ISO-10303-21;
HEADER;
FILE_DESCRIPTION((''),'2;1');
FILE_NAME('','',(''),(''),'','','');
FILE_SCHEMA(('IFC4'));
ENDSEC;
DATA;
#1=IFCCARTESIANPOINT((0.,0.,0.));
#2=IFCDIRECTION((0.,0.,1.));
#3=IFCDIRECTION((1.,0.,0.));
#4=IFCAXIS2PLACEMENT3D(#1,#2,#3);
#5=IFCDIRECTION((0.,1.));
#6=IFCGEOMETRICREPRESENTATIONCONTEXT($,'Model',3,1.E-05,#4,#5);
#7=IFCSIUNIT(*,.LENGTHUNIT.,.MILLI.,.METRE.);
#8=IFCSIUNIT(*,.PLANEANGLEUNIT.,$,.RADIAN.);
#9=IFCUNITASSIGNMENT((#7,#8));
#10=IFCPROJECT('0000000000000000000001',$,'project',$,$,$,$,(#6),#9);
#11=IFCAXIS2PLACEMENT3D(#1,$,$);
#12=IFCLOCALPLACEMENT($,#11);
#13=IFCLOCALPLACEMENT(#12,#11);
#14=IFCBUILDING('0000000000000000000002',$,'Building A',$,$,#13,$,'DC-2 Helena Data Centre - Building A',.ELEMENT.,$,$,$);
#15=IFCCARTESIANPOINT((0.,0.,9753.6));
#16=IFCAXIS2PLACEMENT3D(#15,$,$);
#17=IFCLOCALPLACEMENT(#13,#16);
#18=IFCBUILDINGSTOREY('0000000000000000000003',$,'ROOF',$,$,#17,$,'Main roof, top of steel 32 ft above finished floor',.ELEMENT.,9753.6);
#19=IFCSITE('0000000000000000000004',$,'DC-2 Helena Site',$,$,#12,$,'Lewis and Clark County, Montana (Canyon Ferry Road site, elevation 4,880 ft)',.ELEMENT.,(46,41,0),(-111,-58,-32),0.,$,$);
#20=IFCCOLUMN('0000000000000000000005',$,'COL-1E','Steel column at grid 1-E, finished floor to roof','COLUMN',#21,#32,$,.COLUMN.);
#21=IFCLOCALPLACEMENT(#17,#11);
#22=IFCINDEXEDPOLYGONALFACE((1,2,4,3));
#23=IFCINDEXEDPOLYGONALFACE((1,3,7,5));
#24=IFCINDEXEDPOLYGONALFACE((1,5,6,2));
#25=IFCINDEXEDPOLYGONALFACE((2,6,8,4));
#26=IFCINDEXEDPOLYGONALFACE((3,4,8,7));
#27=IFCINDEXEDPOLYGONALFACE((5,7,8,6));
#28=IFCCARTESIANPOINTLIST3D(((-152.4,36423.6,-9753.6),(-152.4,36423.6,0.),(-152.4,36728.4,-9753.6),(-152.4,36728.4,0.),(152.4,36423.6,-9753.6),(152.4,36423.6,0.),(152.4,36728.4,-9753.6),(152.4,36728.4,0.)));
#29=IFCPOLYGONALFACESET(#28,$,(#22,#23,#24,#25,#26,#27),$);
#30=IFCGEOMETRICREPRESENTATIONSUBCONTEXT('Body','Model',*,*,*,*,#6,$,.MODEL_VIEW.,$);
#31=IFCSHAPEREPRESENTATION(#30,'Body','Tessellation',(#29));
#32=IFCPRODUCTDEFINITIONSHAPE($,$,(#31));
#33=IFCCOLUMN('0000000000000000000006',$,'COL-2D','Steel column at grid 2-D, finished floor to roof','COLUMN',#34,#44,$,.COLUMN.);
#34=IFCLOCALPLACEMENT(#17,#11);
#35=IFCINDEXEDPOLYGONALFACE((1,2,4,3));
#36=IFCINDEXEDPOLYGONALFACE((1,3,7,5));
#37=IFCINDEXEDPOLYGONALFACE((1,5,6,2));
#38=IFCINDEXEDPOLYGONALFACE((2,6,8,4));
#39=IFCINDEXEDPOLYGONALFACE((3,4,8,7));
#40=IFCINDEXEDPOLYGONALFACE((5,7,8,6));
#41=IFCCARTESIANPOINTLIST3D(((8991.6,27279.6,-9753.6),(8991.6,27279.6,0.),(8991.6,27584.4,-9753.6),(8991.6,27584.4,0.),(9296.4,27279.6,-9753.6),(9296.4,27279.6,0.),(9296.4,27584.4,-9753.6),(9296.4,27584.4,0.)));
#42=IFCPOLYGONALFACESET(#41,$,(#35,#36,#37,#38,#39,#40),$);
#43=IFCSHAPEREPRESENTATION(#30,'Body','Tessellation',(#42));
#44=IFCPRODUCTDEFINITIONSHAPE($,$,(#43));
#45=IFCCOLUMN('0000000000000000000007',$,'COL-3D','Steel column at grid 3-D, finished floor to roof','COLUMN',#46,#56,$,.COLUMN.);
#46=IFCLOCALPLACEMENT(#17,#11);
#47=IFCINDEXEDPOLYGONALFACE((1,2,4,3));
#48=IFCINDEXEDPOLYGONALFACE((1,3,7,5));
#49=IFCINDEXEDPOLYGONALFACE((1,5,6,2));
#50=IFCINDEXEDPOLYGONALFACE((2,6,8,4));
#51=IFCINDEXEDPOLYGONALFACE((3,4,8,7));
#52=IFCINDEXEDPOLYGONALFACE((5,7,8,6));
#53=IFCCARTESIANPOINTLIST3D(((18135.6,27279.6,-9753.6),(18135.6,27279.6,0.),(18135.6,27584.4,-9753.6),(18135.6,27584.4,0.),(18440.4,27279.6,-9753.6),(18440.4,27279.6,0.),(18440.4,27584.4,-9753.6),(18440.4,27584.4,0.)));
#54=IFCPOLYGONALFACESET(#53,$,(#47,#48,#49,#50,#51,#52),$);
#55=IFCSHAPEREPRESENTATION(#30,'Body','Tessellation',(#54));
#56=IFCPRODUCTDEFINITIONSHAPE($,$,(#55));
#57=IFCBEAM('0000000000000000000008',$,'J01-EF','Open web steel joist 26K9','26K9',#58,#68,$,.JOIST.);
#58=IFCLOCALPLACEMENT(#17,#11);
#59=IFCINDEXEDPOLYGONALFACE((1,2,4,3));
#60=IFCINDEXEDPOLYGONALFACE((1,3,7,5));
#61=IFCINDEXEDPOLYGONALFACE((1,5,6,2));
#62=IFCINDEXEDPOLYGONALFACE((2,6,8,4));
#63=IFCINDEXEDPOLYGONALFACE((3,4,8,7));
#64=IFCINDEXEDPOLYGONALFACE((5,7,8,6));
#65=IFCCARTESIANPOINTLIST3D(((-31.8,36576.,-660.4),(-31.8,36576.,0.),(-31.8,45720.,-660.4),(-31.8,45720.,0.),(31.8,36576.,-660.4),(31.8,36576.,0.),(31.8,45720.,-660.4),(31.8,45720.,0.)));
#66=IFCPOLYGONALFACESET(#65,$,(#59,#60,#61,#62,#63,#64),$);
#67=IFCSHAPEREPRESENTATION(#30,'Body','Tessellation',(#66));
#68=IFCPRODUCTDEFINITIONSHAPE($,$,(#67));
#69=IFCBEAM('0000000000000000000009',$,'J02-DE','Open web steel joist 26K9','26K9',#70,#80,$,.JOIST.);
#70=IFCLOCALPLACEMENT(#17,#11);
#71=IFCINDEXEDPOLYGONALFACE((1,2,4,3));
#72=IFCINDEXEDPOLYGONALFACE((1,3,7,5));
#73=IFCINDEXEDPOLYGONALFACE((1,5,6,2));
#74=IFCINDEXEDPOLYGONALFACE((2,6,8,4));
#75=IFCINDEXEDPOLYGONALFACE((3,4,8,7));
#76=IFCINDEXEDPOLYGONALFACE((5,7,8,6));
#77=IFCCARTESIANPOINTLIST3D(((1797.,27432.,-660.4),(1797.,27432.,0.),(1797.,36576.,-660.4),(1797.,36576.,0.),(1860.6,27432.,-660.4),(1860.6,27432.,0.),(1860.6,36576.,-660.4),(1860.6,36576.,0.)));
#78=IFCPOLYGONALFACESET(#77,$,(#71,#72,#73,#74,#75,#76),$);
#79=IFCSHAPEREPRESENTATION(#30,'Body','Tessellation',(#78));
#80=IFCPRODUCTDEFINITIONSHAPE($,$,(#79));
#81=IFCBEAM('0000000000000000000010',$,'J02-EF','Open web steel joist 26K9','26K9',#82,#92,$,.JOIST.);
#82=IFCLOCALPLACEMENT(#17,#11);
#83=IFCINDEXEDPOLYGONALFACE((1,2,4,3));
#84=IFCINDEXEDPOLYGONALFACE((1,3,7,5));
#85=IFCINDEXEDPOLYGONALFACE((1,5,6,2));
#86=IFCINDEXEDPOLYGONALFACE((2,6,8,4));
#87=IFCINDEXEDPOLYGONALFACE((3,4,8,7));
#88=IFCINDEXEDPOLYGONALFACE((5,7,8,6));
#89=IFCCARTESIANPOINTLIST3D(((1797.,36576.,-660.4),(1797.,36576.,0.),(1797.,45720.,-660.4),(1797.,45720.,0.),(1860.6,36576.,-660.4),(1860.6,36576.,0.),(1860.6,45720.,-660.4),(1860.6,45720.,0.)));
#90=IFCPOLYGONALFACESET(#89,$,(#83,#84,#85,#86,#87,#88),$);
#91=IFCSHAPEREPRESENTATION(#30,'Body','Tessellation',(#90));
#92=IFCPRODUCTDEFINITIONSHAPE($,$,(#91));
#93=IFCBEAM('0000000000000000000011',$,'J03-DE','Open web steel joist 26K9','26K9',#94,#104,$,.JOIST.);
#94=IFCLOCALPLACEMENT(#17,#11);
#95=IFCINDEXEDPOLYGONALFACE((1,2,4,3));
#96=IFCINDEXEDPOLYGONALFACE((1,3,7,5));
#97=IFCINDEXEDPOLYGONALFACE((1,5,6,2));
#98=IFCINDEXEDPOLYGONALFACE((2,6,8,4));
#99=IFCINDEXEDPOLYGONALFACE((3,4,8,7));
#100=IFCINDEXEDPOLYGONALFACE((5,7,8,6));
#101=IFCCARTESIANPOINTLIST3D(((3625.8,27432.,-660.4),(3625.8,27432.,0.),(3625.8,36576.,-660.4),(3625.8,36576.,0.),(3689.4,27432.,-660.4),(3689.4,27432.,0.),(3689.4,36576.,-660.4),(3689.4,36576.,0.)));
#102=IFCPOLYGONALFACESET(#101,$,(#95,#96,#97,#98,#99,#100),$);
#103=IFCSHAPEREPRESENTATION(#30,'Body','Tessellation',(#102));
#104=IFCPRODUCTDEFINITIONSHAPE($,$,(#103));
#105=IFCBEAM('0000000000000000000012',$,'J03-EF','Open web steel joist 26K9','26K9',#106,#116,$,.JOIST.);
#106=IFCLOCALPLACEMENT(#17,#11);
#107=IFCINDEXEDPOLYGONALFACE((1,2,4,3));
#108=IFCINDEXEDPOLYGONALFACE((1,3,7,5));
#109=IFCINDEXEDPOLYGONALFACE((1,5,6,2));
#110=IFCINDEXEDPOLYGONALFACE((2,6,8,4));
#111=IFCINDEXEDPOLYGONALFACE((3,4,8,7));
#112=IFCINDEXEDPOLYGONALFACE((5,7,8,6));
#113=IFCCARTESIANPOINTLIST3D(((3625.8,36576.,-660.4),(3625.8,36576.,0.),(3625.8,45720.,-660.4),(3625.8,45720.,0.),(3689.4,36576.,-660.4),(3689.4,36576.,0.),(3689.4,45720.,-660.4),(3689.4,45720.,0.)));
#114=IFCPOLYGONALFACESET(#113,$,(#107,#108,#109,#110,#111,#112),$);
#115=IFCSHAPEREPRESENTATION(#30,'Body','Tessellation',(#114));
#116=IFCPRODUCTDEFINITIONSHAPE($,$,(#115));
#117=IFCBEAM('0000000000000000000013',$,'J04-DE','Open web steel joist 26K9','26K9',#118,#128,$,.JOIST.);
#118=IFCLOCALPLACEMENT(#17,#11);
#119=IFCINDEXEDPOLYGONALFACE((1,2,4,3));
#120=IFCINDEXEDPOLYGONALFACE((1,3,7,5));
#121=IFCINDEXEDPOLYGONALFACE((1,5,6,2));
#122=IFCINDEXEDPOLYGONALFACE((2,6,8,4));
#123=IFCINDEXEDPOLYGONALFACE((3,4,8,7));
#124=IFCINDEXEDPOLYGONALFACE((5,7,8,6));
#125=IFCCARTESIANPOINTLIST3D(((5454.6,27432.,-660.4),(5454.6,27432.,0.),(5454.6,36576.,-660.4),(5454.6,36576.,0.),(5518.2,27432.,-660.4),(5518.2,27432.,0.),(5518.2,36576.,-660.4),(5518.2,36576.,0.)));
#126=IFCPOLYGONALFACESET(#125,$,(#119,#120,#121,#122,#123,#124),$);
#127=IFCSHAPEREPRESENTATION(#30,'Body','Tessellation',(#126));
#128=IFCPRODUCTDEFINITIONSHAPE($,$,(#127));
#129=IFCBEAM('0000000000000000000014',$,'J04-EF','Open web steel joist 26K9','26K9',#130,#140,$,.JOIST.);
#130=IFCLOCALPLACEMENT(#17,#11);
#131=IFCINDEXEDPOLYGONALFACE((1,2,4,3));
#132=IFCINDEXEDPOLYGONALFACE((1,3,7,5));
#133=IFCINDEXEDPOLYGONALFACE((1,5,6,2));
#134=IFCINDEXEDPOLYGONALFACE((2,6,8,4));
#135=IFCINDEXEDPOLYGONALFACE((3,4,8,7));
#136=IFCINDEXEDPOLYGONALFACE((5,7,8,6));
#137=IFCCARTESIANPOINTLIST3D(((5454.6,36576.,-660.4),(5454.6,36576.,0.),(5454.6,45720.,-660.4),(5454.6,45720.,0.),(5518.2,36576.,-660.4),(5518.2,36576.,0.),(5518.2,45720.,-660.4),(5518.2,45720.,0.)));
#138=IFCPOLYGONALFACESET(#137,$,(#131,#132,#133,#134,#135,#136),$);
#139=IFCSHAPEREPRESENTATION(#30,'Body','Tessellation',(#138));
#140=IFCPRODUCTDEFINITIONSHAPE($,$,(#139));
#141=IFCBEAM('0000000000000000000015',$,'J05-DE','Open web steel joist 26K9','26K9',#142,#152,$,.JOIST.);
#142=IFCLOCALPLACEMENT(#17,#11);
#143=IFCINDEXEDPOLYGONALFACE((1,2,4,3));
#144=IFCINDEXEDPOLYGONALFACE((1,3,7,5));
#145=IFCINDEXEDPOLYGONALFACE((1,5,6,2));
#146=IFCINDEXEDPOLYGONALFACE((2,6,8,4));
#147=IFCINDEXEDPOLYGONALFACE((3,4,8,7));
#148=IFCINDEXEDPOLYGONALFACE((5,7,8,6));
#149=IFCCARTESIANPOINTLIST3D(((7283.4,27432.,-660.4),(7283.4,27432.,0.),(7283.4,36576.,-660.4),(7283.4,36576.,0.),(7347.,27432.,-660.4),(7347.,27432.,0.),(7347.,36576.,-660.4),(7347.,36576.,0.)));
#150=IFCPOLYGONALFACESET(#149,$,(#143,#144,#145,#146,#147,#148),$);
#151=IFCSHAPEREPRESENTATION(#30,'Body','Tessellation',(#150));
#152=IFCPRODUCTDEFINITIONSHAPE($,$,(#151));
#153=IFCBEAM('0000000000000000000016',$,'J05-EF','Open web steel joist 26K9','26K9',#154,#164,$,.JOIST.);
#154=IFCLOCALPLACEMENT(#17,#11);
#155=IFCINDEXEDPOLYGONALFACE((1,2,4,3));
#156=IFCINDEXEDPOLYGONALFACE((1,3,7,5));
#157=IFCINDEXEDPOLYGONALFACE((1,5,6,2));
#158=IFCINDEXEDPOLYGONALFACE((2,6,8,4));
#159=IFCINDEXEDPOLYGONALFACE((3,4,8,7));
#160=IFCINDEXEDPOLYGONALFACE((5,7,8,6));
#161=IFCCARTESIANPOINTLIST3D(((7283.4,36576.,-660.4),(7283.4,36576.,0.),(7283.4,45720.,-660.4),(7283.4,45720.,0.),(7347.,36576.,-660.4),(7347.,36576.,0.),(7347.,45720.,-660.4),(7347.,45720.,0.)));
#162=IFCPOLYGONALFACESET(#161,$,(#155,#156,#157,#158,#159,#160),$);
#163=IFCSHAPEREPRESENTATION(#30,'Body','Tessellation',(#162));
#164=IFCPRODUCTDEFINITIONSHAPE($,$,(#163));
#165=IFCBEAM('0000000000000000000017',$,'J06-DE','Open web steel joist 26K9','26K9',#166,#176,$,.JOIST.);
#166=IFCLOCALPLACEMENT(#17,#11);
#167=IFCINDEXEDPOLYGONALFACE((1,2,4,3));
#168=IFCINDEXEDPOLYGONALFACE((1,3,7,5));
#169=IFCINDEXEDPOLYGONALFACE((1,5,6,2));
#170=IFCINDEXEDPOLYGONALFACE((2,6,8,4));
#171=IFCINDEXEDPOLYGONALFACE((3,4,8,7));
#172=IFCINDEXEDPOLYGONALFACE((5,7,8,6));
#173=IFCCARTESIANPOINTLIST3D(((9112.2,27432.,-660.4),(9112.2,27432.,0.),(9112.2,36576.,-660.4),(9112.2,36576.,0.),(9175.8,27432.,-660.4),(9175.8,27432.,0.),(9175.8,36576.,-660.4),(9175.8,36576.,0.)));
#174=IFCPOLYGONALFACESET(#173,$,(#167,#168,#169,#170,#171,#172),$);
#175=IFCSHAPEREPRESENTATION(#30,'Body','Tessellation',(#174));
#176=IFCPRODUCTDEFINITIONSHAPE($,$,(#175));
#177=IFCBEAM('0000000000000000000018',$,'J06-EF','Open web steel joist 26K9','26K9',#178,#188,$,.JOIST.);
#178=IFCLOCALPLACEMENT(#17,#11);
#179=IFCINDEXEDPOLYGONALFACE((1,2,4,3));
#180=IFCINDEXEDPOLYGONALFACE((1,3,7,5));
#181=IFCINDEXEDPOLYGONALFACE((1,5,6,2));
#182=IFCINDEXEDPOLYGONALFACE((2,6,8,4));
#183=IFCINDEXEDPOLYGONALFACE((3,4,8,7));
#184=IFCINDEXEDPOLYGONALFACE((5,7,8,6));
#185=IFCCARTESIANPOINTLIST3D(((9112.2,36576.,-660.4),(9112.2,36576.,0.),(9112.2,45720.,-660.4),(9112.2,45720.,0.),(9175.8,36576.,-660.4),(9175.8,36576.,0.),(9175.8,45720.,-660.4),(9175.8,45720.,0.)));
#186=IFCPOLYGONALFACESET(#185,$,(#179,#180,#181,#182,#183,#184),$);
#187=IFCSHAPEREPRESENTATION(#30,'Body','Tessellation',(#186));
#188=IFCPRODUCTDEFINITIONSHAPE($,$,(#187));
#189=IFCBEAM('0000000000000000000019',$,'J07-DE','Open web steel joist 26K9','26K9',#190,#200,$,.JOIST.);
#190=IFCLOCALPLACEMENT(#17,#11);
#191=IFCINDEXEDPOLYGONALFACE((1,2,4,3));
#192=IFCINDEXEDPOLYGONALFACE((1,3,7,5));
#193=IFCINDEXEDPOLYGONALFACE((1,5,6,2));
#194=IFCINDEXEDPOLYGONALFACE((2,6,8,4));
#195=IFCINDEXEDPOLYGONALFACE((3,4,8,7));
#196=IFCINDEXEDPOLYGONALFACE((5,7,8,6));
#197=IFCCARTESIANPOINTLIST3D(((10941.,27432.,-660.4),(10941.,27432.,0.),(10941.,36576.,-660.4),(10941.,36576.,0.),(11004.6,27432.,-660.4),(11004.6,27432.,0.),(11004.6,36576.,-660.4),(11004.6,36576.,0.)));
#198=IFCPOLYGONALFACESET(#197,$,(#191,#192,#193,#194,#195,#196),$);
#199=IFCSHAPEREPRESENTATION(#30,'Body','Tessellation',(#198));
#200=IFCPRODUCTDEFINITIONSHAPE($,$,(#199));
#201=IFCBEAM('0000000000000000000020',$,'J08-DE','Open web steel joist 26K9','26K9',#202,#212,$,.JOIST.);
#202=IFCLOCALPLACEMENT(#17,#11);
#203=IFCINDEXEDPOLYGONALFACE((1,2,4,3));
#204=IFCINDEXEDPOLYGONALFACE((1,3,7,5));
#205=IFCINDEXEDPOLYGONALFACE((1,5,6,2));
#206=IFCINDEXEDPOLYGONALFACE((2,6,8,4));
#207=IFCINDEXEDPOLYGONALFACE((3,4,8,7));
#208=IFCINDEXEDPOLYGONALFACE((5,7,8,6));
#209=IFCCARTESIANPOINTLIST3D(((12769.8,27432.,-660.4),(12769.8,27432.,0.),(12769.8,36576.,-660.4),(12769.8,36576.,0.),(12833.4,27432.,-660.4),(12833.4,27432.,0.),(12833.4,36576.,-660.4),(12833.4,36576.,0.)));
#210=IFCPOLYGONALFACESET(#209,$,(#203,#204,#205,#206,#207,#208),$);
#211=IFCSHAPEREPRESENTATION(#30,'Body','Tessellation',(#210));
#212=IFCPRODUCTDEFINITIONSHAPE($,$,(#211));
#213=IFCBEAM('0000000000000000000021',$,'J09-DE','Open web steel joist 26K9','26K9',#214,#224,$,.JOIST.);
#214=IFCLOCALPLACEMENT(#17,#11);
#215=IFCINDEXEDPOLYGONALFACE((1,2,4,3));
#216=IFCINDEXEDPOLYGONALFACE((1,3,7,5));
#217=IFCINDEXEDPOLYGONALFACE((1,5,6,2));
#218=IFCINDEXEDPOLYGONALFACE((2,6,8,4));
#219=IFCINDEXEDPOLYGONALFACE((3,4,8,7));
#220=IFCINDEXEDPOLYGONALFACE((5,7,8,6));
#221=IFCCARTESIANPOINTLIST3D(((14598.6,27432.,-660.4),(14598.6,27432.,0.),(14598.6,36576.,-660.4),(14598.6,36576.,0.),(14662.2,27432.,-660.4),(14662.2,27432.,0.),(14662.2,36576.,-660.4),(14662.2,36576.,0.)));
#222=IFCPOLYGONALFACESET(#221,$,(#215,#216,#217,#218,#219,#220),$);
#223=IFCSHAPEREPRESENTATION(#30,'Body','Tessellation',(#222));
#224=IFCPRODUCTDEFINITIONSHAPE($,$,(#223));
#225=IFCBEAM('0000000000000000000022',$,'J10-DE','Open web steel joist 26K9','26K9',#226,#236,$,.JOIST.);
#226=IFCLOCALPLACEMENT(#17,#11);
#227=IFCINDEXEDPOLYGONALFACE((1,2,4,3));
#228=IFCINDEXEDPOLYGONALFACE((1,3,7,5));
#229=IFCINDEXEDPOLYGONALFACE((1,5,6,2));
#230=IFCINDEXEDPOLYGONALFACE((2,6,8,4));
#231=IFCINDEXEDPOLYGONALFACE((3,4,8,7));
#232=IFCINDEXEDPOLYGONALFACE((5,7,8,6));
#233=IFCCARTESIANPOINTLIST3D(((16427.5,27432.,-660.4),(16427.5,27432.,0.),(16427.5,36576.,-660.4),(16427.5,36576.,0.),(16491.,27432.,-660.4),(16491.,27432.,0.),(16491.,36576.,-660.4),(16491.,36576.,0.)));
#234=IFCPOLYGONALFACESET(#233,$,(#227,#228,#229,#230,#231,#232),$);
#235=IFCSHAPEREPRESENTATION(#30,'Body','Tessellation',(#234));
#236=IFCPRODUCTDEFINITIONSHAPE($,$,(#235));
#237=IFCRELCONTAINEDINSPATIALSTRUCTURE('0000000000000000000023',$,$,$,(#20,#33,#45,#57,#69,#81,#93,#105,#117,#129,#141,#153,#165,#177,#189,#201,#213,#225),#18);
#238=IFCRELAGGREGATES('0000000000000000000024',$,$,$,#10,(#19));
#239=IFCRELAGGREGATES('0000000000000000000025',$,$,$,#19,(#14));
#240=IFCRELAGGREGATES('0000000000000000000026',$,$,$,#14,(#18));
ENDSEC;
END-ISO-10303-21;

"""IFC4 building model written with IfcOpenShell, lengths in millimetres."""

from ifc_helpers import new_model, si_unit, direction, frame, origin, origin_with_axes, origin_2d, place, context, subcontext, project, spatial, rectangle, extrude, element, save


model = new_model("IFC4")

# Units and contexts
model_context = context("Model", 3, precision=1e-05, world=origin_with_axes(), true_north=direction((0.0, 1.0)))
body_context = subcontext(model_context, "Body", "Model", "MODEL_VIEW")
ifc_project = project(units=[si_unit("LENGTHUNIT", "METRE", prefix="MILLI"), si_unit("PLANEANGLEUNIT", "RADIAN")], contexts=[model_context])

# Site, building, storey
site_placement = place(None, origin())
site = spatial("IfcSite", under=ifc_project, at=site_placement, Name="DC-2 Helena Site", LongName="Lewis and Clark County, Montana (Canyon Ferry Road site, elevation 4,880 ft)", CompositionType="ELEMENT", RefLatitude=(46, 41, 0), RefLongitude=(-111, -58, -32), RefElevation=0.0)
building_placement = place(site_placement, origin())
building = spatial("IfcBuilding", under=site, at=building_placement, Name="Building A", LongName="DC-2 Helena Data Centre - Building A", CompositionType="ELEMENT")
storey_placement = place(building_placement, frame((0.0, 0.0, 9753.6)))
storey = spatial("IfcBuildingStorey", under=building, at=storey_placement, Name="ROOF", LongName="Main roof, top of steel 32 ft above finished floor", CompositionType="ELEMENT", Elevation=9753.6)

# Columns
placement_1 = place(storey_placement, frame((0.0, 36576.0, -9753.6)))
element("IfcColumn", 1, at=placement_1, inside=storey, Name="COL-1E", Description="Steel column at grid 1-E, finished floor to roof", ObjectType="COLUMN", PredefinedType="COLUMN", context=body_context, shape_type="SweptSolid", body=[
    extrude(rectangle(XDim=304.8, YDim=304.8, at=origin_2d()), origin(), (0.0, 0.0, 1.0), 9753.6),
])
for number, where, name, description in (
    (2, (9144.0, 27432.0, -9753.6), "COL-2D", "Steel column at grid 2-D, finished floor to roof"),
    (3, (18288.0, 27432.0, -9753.6), "COL-3D", "Steel column at grid 3-D, finished floor to roof"),
):
    element("IfcColumn", number, at=place(storey_placement, frame(where)), inside=storey, Name=name, Description=description, ObjectType="COLUMN", PredefinedType="COLUMN", context=body_context, shape_type="SweptSolid", body=[
        extrude(rectangle(XDim=304.8, YDim=304.8, at=origin_2d()), origin(), (0.0, 0.0, 1.0), 9753.6),
    ])

# Beams
placement_2 = place(storey_placement, frame((0.0, 36576.0, 0.0)))
element("IfcBeam", 4, at=placement_2, inside=storey, Name="J01-EF", Description="Open web steel joist 26K9", ObjectType="26K9", PredefinedType="JOIST", context=body_context, shape_type="SweptSolid", body=[
    extrude(rectangle(XDim=63.5, YDim=660.4, at=origin_2d()), frame((0.0, 0.0, -330.2), z_axis=(0.0, 1.0, 0.0), x_axis=(1.0, 0.0, 0.0)), (0.0, 0.0, 1.0), 9144.0),
])
for number, where, name in (
    (5, (1828.8, 27432.0, 0.0), "J02-DE"),
    (6, (1828.8, 36576.0, 0.0), "J02-EF"),
    (7, (3657.6, 27432.0, 0.0), "J03-DE"),
    (8, (3657.6, 36576.0, 0.0), "J03-EF"),
    (9, (5486.4, 27432.0, 0.0), "J04-DE"),
    (10, (5486.4, 36576.0, 0.0), "J04-EF"),
    (11, (7315.2, 27432.0, 0.0), "J05-DE"),
    (12, (7315.2, 36576.0, 0.0), "J05-EF"),
):
    element("IfcBeam", number, at=place(storey_placement, frame(where)), inside=storey, Name=name, Description="Open web steel joist 26K9", ObjectType="26K9", PredefinedType="JOIST", context=body_context, shape_type="SweptSolid", body=[
        extrude(rectangle(XDim=63.5, YDim=660.4, at=origin_2d()), frame((0.0, 0.0, -330.2), z_axis=(0.0, 1.0, 0.0), x_axis=(1.0, 0.0, 0.0)), (0.0, 0.0, 1.0), 9144.0),
    ])
placement_3 = place(storey_placement, frame((9144.0, 27432.0, 0.0)))
element("IfcBeam", 13, at=placement_3, inside=storey, Name="J06-DE", Description="Open web steel joist 26K9", ObjectType="26K9", PredefinedType="JOIST", context=body_context, shape_type="SweptSolid", body=[
    extrude(rectangle(XDim=63.5, YDim=660.4, at=origin_2d()), frame((0.0, 0.0, -330.2), z_axis=(0.0, 1.0, 0.0), x_axis=(1.0, 0.0, 0.0)), (0.0, 0.0, 1.0), 9144.0),
])
placement_4 = place(storey_placement, frame((9144.0, 36576.0, 0.0)))
element("IfcBeam", 14, at=placement_4, inside=storey, Name="J06-EF", Description="Open web steel joist 26K9", ObjectType="26K9", PredefinedType="JOIST", context=body_context, shape_type="SweptSolid", body=[
    extrude(rectangle(XDim=63.5, YDim=660.4, at=origin_2d()), frame((0.0, 0.0, -330.2), z_axis=(0.0, 1.0, 0.0), x_axis=(1.0, 0.0, 0.0)), (0.0, 0.0, 1.0), 9144.0),
])
for number, where, name in (
    (15, (10972.8, 27432.0, 0.0), "J07-DE"),
    (16, (12801.6, 27432.0, 0.0), "J08-DE"),
    (17, (14630.4, 27432.0, 0.0), "J09-DE"),
    (18, (16459.2, 27432.0, 0.0), "J10-DE"),
):
    element("IfcBeam", number, at=place(storey_placement, frame(where)), inside=storey, Name=name, Description="Open web steel joist 26K9", ObjectType="26K9", PredefinedType="JOIST", context=body_context, shape_type="SweptSolid", body=[
        extrude(rectangle(XDim=63.5, YDim=660.4, at=origin_2d()), frame((0.0, 0.0, -330.2), z_axis=(0.0, 1.0, 0.0), x_axis=(1.0, 0.0, 0.0)), (0.0, 0.0, 1.0), 9144.0),
    ])

save(model, "model.ifc")
